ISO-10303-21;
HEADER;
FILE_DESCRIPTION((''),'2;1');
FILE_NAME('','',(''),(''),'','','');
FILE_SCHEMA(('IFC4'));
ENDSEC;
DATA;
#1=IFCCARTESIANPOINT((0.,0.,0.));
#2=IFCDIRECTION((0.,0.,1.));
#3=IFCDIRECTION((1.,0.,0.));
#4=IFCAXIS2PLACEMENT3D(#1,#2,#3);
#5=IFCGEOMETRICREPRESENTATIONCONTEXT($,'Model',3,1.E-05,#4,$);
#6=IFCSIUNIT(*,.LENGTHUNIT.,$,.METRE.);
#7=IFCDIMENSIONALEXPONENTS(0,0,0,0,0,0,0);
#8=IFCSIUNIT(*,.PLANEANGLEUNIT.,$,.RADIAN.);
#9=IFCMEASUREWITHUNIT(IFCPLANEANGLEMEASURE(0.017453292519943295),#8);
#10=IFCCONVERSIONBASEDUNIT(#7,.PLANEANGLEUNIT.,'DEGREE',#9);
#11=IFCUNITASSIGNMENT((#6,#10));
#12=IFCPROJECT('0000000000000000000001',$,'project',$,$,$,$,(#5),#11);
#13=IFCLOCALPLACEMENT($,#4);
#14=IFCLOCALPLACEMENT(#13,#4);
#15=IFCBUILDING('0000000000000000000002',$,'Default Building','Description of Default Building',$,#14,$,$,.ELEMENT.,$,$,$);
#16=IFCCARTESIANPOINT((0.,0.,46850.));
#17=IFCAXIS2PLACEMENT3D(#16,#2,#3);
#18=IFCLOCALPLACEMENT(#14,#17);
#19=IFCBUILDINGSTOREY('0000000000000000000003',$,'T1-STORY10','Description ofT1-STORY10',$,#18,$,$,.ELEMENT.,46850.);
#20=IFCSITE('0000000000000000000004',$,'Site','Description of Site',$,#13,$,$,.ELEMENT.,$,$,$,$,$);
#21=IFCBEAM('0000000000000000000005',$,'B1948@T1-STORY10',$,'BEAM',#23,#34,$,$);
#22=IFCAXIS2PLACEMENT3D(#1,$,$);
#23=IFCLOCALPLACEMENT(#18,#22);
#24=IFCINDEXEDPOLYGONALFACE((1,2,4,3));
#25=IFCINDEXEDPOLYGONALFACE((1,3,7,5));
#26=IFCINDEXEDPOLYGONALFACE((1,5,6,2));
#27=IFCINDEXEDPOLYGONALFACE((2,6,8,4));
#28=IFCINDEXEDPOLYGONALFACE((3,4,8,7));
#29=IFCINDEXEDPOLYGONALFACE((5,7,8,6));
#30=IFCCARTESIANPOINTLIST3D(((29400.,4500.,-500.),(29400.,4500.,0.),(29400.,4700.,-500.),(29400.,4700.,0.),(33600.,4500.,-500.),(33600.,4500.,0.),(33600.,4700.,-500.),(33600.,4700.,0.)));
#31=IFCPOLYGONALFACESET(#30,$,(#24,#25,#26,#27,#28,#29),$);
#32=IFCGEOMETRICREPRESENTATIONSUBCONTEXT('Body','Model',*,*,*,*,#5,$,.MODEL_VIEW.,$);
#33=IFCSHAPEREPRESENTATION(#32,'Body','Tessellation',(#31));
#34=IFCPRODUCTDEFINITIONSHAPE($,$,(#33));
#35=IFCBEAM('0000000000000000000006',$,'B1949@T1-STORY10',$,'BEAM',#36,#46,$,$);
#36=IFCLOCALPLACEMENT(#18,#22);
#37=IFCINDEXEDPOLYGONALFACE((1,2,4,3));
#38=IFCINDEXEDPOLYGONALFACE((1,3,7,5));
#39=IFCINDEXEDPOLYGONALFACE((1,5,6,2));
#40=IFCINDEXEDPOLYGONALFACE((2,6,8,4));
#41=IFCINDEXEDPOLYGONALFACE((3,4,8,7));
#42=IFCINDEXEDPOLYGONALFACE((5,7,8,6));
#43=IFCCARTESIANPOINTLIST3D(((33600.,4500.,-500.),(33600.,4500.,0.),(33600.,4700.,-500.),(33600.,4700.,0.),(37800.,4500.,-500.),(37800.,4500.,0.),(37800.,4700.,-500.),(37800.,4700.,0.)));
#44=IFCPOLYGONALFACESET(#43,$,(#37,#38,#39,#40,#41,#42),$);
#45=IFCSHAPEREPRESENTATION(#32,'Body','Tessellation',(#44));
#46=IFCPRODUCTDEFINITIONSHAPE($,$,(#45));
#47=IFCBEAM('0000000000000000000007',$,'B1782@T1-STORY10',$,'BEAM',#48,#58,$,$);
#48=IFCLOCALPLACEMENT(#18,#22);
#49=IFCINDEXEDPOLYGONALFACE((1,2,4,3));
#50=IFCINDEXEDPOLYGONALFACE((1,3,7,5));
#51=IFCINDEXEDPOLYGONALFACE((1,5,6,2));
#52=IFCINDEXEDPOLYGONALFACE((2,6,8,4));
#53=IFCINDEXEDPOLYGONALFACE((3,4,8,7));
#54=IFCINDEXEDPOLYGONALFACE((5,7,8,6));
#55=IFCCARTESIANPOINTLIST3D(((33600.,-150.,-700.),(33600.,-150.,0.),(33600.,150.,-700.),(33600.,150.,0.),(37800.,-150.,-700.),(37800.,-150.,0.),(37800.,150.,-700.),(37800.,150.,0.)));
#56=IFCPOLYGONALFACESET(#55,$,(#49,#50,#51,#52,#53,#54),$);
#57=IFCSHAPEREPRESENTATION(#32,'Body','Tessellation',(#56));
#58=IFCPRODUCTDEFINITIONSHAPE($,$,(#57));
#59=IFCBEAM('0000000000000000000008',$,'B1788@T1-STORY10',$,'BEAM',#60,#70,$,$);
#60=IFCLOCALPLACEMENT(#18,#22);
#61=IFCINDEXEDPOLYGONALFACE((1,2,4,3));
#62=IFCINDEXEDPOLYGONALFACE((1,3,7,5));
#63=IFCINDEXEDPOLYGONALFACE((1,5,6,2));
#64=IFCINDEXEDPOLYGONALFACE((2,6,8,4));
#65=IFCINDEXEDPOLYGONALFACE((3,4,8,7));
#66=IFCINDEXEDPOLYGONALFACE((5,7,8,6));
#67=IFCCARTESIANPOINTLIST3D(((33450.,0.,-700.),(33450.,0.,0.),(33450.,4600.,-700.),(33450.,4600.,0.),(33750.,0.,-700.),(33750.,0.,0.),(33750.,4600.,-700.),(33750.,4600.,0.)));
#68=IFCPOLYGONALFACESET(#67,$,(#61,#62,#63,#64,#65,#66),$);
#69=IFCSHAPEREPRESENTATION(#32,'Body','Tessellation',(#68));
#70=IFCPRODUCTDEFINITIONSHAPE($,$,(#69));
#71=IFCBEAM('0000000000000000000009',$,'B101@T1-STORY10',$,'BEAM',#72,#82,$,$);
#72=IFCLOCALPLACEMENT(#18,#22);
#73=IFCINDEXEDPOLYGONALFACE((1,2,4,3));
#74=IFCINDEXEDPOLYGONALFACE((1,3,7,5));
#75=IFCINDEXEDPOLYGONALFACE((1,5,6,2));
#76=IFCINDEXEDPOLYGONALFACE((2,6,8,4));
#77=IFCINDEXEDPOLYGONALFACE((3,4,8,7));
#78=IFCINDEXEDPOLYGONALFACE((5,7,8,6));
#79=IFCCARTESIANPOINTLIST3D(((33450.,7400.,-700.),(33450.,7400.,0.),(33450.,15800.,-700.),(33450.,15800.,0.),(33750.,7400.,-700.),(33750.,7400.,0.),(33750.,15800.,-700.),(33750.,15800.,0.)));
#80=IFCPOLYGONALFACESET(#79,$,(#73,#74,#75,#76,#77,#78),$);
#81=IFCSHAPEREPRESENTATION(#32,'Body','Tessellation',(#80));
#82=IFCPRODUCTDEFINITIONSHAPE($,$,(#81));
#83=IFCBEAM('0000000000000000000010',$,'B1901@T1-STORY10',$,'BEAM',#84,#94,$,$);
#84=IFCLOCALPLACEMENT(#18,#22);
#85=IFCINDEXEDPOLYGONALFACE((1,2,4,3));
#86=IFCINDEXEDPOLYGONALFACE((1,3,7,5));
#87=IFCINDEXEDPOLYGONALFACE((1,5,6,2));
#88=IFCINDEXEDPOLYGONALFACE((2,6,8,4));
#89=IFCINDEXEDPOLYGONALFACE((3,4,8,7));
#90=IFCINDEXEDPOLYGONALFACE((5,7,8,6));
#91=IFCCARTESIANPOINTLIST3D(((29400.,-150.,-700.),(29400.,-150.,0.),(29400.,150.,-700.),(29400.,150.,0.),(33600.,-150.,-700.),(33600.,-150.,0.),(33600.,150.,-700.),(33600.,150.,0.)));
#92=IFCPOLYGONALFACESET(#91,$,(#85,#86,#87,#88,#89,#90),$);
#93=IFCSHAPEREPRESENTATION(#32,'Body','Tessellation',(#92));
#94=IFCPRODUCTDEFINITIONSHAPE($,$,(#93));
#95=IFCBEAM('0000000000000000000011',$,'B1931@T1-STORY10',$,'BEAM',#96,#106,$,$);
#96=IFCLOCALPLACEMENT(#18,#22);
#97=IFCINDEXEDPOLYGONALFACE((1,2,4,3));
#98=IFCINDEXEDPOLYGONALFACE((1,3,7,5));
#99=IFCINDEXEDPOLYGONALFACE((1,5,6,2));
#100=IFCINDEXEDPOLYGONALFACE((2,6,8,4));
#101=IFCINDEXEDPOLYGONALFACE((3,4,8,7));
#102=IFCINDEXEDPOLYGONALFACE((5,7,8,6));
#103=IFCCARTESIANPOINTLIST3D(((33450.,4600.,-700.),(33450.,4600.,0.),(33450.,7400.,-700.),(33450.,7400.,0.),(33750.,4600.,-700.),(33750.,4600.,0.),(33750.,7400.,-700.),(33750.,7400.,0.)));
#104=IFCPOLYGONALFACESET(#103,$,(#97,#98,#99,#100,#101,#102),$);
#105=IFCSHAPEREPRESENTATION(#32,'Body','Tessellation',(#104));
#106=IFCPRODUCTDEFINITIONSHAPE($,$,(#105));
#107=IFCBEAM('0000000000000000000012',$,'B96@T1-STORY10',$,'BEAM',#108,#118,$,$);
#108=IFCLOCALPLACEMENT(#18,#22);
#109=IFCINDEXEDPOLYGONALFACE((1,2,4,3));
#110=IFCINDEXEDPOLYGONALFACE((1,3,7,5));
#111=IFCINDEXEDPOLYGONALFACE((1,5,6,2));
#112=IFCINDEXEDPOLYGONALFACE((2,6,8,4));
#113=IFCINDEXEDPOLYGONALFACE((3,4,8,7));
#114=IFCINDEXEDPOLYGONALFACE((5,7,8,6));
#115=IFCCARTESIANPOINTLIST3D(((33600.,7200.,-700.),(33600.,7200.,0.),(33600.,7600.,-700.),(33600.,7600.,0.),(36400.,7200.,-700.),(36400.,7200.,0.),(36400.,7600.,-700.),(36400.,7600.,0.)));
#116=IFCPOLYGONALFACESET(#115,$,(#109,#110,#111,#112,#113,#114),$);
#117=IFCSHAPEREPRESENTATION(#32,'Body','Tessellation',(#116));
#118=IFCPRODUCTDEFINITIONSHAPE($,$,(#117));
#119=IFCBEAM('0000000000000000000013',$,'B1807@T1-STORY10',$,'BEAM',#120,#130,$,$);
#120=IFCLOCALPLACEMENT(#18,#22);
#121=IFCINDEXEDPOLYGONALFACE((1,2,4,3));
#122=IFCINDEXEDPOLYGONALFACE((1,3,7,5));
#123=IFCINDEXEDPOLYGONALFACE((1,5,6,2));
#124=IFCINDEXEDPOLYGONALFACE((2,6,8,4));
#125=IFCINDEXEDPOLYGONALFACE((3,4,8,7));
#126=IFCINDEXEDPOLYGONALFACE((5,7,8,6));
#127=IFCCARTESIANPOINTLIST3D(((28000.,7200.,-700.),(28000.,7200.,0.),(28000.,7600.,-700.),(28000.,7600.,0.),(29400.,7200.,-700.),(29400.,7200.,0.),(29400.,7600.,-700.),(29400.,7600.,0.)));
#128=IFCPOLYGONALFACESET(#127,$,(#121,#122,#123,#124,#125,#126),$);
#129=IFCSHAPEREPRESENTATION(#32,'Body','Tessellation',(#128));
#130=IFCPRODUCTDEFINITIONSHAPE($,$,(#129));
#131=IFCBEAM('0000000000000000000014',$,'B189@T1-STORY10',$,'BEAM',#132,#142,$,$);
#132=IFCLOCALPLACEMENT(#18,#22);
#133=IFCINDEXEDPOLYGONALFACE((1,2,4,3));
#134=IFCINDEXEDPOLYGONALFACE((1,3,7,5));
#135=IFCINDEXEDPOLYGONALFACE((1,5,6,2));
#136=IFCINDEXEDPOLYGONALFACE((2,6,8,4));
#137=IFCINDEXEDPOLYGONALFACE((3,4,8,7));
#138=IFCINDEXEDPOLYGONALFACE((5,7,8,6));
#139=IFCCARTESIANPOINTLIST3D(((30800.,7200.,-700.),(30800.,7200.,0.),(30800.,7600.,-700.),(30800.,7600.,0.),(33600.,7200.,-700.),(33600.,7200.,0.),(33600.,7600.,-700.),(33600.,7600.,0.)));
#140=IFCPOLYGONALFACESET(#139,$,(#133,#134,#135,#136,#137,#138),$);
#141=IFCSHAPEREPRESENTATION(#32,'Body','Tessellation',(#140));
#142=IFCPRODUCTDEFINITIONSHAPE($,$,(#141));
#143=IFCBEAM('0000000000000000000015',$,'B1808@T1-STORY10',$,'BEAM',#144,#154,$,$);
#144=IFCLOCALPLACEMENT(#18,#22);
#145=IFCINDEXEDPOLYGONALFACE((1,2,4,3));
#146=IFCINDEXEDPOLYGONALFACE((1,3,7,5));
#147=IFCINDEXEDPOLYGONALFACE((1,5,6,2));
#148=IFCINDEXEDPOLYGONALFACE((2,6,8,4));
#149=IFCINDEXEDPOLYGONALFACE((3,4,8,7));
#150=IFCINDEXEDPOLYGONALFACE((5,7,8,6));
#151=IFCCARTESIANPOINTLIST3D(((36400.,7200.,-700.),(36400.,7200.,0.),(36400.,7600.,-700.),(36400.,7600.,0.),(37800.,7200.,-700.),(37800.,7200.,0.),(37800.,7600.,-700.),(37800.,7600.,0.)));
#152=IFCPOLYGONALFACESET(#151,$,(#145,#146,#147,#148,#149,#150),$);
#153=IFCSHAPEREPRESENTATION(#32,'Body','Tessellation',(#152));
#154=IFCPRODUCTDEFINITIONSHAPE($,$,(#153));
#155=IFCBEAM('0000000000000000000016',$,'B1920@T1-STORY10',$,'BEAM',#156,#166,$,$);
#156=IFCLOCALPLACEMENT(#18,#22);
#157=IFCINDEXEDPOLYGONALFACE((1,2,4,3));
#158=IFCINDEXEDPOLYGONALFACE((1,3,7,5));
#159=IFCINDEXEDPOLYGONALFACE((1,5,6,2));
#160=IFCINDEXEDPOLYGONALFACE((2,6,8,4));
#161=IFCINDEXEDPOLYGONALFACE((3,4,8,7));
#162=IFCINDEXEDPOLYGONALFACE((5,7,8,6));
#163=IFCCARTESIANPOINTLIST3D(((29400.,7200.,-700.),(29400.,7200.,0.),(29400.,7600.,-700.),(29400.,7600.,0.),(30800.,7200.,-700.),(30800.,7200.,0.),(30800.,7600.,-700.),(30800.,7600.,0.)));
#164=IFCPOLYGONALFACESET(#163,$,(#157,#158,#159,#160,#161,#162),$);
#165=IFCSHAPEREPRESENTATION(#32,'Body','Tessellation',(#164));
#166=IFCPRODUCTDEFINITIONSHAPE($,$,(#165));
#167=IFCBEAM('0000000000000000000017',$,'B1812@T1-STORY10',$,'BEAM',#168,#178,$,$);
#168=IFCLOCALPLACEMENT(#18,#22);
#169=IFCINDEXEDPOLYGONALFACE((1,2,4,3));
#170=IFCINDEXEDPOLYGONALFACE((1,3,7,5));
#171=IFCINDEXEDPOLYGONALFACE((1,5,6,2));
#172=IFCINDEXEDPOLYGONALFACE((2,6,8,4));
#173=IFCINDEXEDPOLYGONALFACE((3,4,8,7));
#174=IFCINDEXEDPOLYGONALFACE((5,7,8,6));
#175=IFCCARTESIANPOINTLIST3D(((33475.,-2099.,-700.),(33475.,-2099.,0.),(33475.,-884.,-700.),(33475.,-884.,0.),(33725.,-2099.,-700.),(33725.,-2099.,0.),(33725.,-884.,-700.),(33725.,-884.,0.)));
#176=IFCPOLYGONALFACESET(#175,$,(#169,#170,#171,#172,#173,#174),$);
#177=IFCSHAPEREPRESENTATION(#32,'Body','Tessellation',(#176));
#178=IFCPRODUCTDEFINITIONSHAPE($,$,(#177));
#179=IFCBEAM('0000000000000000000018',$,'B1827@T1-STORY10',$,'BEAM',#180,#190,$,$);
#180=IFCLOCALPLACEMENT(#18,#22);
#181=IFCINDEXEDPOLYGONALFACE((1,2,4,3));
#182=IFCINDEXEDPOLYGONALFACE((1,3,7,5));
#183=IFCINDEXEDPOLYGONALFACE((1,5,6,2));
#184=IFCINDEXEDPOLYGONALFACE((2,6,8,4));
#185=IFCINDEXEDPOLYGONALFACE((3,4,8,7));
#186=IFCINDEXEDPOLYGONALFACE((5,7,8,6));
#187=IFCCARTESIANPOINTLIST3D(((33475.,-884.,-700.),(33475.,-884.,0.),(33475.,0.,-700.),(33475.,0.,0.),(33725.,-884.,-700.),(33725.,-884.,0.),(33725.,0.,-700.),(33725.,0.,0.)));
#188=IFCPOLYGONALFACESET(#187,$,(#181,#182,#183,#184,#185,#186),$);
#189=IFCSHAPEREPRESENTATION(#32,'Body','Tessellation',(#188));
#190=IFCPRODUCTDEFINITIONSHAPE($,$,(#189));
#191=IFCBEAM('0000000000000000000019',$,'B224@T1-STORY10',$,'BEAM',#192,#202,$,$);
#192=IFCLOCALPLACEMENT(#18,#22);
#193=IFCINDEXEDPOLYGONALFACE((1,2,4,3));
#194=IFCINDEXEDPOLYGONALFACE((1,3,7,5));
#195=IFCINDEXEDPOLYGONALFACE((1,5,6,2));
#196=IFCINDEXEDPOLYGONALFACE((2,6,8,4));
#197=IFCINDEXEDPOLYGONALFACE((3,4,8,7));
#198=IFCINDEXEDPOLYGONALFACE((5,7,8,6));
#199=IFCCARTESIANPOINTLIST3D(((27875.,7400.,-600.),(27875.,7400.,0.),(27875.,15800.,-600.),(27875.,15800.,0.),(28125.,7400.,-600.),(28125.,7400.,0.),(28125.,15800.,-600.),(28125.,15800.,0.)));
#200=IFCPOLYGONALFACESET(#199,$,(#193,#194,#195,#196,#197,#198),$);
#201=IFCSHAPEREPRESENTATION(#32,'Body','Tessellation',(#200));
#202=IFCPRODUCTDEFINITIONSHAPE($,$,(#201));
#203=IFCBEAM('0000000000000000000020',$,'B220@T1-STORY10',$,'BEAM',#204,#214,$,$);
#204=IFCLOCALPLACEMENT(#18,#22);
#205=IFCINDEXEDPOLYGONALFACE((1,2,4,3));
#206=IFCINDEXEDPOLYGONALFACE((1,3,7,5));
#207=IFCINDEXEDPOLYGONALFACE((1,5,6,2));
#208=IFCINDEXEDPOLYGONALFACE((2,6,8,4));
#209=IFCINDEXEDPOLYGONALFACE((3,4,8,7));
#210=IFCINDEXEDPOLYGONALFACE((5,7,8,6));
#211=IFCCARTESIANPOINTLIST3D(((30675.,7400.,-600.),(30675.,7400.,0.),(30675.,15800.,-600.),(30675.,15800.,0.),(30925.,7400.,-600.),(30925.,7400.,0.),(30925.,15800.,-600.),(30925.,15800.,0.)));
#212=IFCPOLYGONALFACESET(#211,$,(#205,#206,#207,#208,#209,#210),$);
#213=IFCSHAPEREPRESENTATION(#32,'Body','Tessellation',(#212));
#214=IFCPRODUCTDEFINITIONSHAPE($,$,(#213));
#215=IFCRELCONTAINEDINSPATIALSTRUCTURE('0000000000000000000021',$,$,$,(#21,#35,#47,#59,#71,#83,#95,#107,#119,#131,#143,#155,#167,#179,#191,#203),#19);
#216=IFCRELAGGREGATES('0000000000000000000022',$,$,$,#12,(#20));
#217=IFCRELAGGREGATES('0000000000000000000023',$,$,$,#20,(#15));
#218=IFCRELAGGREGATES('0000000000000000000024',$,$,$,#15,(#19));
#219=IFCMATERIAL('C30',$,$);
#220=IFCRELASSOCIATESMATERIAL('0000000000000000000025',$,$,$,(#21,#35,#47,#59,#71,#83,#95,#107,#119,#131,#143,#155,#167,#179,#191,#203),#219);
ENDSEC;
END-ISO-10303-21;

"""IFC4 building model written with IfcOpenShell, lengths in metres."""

from ifc_helpers import new_model, entity, si_unit, converted_unit, frame, origin_with_axes, place, context, subcontext, project, spatial, rectangle, extrude, material, element, save


model = new_model("IFC4")

# Units and contexts
model_context = context("Model", 3, precision=1e-05, world=origin_with_axes())
body_context = subcontext(model_context, "Body", "Model", "MODEL_VIEW")
ifc_project = project(units=[si_unit("LENGTHUNIT", "METRE"), converted_unit("PLANEANGLEUNIT", "DEGREE", entity("IfcPlaneAngleMeasure", 0.017453292519943295), si_unit("PLANEANGLEUNIT", "RADIAN"), dimensions=[0, 0, 0, 0, 0, 0, 0])], contexts=[model_context])

# Site, building, storey
site_placement = place(None, origin_with_axes())
site = spatial("IfcSite", under=ifc_project, at=site_placement, Name="Site", Description="Description of Site", CompositionType="ELEMENT")
building_placement = place(site_placement, origin_with_axes())
building = spatial("IfcBuilding", under=site, at=building_placement, Name="Default Building", Description="Description of Default Building", CompositionType="ELEMENT")
storey_placement = place(building_placement, frame((0.0, 0.0, 46850.0), z_axis=(0.0, 0.0, 1.0), x_axis=(1.0, 0.0, 0.0)))
storey = spatial("IfcBuildingStorey", under=building, at=storey_placement, Name="T1-STORY10", Description="Description ofT1-STORY10", CompositionType="ELEMENT", Elevation=46850.0)

# Beams
ifc_material_1 = material(Name="C30")
for number, where, z_axis, x_axis, name in (
    (1, (29400.0, 4600.0, -250.0), (1.0, 0.0, 0.0), (0.0, 1.0, 0.0), "B1948@T1-STORY10"),
    (2, (33600.0, 4600.0, -250.0), (1.0, 0.0, 0.0), (0.0, 1.0, 0.0), "B1949@T1-STORY10"),
):
    element("IfcBeam", number, at=place(storey_placement, frame(where, z_axis=z_axis, x_axis=x_axis)), inside=storey, material=ifc_material_1, Name=name, ObjectType="BEAM", context=body_context, shape_type="SweptSolid", body=[
        extrude(rectangle(XDim=200.0, YDim=500.0), origin_with_axes(), (0.0, 0.0, 1.0), 4200.0),
    ])
beam_1_placement = place(storey_placement, frame((33600.0, 0.0, -350.0), z_axis=(1.0, 0.0, 0.0), x_axis=(0.0, 1.0, 0.0)))
element("IfcBeam", 3, at=beam_1_placement, inside=storey, material=ifc_material_1, Name="B1782@T1-STORY10", ObjectType="BEAM", context=body_context, shape_type="SweptSolid", body=[
    extrude(rectangle(XDim=300.0, YDim=700.0), origin_with_axes(), (0.0, 0.0, 1.0), 4200.0),
])
beam_2_placement = place(storey_placement, frame((33600.0, 0.0, -350.0), z_axis=(0.0, 1.0, 0.0), x_axis=(-1.0, 0.0, 0.0)))
element("IfcBeam", 4, at=beam_2_placement, inside=storey, material=ifc_material_1, Name="B1788@T1-STORY10", ObjectType="BEAM", context=body_context, shape_type="SweptSolid", body=[
    extrude(rectangle(XDim=300.0, YDim=700.0), origin_with_axes(), (0.0, 0.0, 1.0), 4600.0),
])
beam_3_placement = place(storey_placement, frame((33600.0, 7400.0, -350.0), z_axis=(0.0, 1.0, 0.0), x_axis=(-1.0, 0.0, 0.0)))
element("IfcBeam", 5, at=beam_3_placement, inside=storey, material=ifc_material_1, Name="B101@T1-STORY10", ObjectType="BEAM", context=body_context, shape_type="SweptSolid", body=[
    extrude(rectangle(XDim=300.0, YDim=700.0), origin_with_axes(), (0.0, 0.0, 1.0), 8400.0),
])
beam_4_placement = place(storey_placement, frame((29400.0, 0.0, -350.0), z_axis=(1.0, 0.0, 0.0), x_axis=(0.0, 1.0, 0.0)))
element("IfcBeam", 6, at=beam_4_placement, inside=storey, material=ifc_material_1, Name="B1901@T1-STORY10", ObjectType="BEAM", context=body_context, shape_type="SweptSolid", body=[
    extrude(rectangle(XDim=300.0, YDim=700.0), origin_with_axes(), (0.0, 0.0, 1.0), 4200.0),
])
beam_5_placement = place(storey_placement, frame((33600.0, 4600.0, -350.0), z_axis=(0.0, 1.0, 0.0), x_axis=(-1.0, 0.0, 0.0)))
element("IfcBeam", 7, at=beam_5_placement, inside=storey, material=ifc_material_1, Name="B1931@T1-STORY10", ObjectType="BEAM", context=body_context, shape_type="SweptSolid", body=[
    extrude(rectangle(XDim=300.0, YDim=700.0), origin_with_axes(), (0.0, 0.0, 1.0), 2800.0),
])
beam_6_placement = place(storey_placement, frame((33600.0, 7400.0, -350.0), z_axis=(1.0, 0.0, 0.0), x_axis=(0.0, 1.0, 0.0)))
element("IfcBeam", 8, at=beam_6_placement, inside=storey, material=ifc_material_1, Name="B96@T1-STORY10", ObjectType="BEAM", context=body_context, shape_type="SweptSolid", body=[
    extrude(rectangle(XDim=400.0, YDim=700.0), origin_with_axes(), (0.0, 0.0, 1.0), 2800.0),
])
beam_7_placement = place(storey_placement, frame((28000.0, 7400.0, -350.0), z_axis=(1.0, 0.0, 0.0), x_axis=(0.0, 1.0, 0.0)))
element("IfcBeam", 9, at=beam_7_placement, inside=storey, material=ifc_material_1, Name="B1807@T1-STORY10", ObjectType="BEAM", context=body_context, shape_type="SweptSolid", body=[
    extrude(rectangle(XDim=400.0, YDim=700.0), origin_with_axes(), (0.0, 0.0, 1.0), 1400.0),
])
beam_8_placement = place(storey_placement, frame((30800.0, 7400.0, -350.0), z_axis=(1.0, 0.0, 0.0), x_axis=(0.0, 1.0, 0.0)))
element("IfcBeam", 10, at=beam_8_placement, inside=storey, material=ifc_material_1, Name="B189@T1-STORY10", ObjectType="BEAM", context=body_context, shape_type="SweptSolid", body=[
    extrude(rectangle(XDim=400.0, YDim=700.0), origin_with_axes(), (0.0, 0.0, 1.0), 2800.0),
])
for number, where, z_axis, x_axis, name in (
    (11, (36400.0, 7400.0, -350.0), (1.0, 0.0, 0.0), (0.0, 1.0, 0.0), "B1808@T1-STORY10"),
    (12, (29400.0, 7400.0, -350.0), (1.0, 0.0, 0.0), (0.0, 1.0, 0.0), "B1920@T1-STORY10"),
):
    element("IfcBeam", number, at=place(storey_placement, frame(where, z_axis=z_axis, x_axis=x_axis)), inside=storey, material=ifc_material_1, Name=name, ObjectType="BEAM", context=body_context, shape_type="SweptSolid", body=[
        extrude(rectangle(XDim=400.0, YDim=700.0), origin_with_axes(), (0.0, 0.0, 1.0), 1400.0),
    ])
beam_9_placement = place(storey_placement, frame((33600.0, -2099.0, -350.0), z_axis=(0.0, 1.0, 0.0), x_axis=(-1.0, 0.0, 0.0)))
element("IfcBeam", 13, at=beam_9_placement, inside=storey, material=ifc_material_1, Name="B1812@T1-STORY10", ObjectType="BEAM", context=body_context, shape_type="SweptSolid", body=[
    extrude(rectangle(XDim=250.0, YDim=700.0), origin_with_axes(), (0.0, 0.0, 1.0), 1215.0),
])
beam_10_placement = place(storey_placement, frame((33600.0, -884.0, -350.0), z_axis=(0.0, 1.0, 0.0), x_axis=(-1.0, 0.0, 0.0)))
element("IfcBeam", 14, at=beam_10_placement, inside=storey, material=ifc_material_1, Name="B1827@T1-STORY10", ObjectType="BEAM", context=body_context, shape_type="SweptSolid", body=[
    extrude(rectangle(XDim=250.0, YDim=700.0), origin_with_axes(), (0.0, 0.0, 1.0), 884.0),
])
for number, where, z_axis, x_axis, name in (
    (15, (28000.0, 7400.0, -300.0), (0.0, 1.0, 0.0), (-1.0, 0.0, 0.0), "B224@T1-STORY10"),
    (16, (30800.0, 7400.0, -300.0), (0.0, 1.0, 0.0), (-1.0, 0.0, 0.0), "B220@T1-STORY10"),
):
    element("IfcBeam", number, at=place(storey_placement, frame(where, z_axis=z_axis, x_axis=x_axis)), inside=storey, material=ifc_material_1, Name=name, ObjectType="BEAM", context=body_context, shape_type="SweptSolid", body=[
        extrude(rectangle(XDim=250.0, YDim=600.0), origin_with_axes(), (0.0, 0.0, 1.0), 8400.0),
    ])

save(model, "model.ifc")
